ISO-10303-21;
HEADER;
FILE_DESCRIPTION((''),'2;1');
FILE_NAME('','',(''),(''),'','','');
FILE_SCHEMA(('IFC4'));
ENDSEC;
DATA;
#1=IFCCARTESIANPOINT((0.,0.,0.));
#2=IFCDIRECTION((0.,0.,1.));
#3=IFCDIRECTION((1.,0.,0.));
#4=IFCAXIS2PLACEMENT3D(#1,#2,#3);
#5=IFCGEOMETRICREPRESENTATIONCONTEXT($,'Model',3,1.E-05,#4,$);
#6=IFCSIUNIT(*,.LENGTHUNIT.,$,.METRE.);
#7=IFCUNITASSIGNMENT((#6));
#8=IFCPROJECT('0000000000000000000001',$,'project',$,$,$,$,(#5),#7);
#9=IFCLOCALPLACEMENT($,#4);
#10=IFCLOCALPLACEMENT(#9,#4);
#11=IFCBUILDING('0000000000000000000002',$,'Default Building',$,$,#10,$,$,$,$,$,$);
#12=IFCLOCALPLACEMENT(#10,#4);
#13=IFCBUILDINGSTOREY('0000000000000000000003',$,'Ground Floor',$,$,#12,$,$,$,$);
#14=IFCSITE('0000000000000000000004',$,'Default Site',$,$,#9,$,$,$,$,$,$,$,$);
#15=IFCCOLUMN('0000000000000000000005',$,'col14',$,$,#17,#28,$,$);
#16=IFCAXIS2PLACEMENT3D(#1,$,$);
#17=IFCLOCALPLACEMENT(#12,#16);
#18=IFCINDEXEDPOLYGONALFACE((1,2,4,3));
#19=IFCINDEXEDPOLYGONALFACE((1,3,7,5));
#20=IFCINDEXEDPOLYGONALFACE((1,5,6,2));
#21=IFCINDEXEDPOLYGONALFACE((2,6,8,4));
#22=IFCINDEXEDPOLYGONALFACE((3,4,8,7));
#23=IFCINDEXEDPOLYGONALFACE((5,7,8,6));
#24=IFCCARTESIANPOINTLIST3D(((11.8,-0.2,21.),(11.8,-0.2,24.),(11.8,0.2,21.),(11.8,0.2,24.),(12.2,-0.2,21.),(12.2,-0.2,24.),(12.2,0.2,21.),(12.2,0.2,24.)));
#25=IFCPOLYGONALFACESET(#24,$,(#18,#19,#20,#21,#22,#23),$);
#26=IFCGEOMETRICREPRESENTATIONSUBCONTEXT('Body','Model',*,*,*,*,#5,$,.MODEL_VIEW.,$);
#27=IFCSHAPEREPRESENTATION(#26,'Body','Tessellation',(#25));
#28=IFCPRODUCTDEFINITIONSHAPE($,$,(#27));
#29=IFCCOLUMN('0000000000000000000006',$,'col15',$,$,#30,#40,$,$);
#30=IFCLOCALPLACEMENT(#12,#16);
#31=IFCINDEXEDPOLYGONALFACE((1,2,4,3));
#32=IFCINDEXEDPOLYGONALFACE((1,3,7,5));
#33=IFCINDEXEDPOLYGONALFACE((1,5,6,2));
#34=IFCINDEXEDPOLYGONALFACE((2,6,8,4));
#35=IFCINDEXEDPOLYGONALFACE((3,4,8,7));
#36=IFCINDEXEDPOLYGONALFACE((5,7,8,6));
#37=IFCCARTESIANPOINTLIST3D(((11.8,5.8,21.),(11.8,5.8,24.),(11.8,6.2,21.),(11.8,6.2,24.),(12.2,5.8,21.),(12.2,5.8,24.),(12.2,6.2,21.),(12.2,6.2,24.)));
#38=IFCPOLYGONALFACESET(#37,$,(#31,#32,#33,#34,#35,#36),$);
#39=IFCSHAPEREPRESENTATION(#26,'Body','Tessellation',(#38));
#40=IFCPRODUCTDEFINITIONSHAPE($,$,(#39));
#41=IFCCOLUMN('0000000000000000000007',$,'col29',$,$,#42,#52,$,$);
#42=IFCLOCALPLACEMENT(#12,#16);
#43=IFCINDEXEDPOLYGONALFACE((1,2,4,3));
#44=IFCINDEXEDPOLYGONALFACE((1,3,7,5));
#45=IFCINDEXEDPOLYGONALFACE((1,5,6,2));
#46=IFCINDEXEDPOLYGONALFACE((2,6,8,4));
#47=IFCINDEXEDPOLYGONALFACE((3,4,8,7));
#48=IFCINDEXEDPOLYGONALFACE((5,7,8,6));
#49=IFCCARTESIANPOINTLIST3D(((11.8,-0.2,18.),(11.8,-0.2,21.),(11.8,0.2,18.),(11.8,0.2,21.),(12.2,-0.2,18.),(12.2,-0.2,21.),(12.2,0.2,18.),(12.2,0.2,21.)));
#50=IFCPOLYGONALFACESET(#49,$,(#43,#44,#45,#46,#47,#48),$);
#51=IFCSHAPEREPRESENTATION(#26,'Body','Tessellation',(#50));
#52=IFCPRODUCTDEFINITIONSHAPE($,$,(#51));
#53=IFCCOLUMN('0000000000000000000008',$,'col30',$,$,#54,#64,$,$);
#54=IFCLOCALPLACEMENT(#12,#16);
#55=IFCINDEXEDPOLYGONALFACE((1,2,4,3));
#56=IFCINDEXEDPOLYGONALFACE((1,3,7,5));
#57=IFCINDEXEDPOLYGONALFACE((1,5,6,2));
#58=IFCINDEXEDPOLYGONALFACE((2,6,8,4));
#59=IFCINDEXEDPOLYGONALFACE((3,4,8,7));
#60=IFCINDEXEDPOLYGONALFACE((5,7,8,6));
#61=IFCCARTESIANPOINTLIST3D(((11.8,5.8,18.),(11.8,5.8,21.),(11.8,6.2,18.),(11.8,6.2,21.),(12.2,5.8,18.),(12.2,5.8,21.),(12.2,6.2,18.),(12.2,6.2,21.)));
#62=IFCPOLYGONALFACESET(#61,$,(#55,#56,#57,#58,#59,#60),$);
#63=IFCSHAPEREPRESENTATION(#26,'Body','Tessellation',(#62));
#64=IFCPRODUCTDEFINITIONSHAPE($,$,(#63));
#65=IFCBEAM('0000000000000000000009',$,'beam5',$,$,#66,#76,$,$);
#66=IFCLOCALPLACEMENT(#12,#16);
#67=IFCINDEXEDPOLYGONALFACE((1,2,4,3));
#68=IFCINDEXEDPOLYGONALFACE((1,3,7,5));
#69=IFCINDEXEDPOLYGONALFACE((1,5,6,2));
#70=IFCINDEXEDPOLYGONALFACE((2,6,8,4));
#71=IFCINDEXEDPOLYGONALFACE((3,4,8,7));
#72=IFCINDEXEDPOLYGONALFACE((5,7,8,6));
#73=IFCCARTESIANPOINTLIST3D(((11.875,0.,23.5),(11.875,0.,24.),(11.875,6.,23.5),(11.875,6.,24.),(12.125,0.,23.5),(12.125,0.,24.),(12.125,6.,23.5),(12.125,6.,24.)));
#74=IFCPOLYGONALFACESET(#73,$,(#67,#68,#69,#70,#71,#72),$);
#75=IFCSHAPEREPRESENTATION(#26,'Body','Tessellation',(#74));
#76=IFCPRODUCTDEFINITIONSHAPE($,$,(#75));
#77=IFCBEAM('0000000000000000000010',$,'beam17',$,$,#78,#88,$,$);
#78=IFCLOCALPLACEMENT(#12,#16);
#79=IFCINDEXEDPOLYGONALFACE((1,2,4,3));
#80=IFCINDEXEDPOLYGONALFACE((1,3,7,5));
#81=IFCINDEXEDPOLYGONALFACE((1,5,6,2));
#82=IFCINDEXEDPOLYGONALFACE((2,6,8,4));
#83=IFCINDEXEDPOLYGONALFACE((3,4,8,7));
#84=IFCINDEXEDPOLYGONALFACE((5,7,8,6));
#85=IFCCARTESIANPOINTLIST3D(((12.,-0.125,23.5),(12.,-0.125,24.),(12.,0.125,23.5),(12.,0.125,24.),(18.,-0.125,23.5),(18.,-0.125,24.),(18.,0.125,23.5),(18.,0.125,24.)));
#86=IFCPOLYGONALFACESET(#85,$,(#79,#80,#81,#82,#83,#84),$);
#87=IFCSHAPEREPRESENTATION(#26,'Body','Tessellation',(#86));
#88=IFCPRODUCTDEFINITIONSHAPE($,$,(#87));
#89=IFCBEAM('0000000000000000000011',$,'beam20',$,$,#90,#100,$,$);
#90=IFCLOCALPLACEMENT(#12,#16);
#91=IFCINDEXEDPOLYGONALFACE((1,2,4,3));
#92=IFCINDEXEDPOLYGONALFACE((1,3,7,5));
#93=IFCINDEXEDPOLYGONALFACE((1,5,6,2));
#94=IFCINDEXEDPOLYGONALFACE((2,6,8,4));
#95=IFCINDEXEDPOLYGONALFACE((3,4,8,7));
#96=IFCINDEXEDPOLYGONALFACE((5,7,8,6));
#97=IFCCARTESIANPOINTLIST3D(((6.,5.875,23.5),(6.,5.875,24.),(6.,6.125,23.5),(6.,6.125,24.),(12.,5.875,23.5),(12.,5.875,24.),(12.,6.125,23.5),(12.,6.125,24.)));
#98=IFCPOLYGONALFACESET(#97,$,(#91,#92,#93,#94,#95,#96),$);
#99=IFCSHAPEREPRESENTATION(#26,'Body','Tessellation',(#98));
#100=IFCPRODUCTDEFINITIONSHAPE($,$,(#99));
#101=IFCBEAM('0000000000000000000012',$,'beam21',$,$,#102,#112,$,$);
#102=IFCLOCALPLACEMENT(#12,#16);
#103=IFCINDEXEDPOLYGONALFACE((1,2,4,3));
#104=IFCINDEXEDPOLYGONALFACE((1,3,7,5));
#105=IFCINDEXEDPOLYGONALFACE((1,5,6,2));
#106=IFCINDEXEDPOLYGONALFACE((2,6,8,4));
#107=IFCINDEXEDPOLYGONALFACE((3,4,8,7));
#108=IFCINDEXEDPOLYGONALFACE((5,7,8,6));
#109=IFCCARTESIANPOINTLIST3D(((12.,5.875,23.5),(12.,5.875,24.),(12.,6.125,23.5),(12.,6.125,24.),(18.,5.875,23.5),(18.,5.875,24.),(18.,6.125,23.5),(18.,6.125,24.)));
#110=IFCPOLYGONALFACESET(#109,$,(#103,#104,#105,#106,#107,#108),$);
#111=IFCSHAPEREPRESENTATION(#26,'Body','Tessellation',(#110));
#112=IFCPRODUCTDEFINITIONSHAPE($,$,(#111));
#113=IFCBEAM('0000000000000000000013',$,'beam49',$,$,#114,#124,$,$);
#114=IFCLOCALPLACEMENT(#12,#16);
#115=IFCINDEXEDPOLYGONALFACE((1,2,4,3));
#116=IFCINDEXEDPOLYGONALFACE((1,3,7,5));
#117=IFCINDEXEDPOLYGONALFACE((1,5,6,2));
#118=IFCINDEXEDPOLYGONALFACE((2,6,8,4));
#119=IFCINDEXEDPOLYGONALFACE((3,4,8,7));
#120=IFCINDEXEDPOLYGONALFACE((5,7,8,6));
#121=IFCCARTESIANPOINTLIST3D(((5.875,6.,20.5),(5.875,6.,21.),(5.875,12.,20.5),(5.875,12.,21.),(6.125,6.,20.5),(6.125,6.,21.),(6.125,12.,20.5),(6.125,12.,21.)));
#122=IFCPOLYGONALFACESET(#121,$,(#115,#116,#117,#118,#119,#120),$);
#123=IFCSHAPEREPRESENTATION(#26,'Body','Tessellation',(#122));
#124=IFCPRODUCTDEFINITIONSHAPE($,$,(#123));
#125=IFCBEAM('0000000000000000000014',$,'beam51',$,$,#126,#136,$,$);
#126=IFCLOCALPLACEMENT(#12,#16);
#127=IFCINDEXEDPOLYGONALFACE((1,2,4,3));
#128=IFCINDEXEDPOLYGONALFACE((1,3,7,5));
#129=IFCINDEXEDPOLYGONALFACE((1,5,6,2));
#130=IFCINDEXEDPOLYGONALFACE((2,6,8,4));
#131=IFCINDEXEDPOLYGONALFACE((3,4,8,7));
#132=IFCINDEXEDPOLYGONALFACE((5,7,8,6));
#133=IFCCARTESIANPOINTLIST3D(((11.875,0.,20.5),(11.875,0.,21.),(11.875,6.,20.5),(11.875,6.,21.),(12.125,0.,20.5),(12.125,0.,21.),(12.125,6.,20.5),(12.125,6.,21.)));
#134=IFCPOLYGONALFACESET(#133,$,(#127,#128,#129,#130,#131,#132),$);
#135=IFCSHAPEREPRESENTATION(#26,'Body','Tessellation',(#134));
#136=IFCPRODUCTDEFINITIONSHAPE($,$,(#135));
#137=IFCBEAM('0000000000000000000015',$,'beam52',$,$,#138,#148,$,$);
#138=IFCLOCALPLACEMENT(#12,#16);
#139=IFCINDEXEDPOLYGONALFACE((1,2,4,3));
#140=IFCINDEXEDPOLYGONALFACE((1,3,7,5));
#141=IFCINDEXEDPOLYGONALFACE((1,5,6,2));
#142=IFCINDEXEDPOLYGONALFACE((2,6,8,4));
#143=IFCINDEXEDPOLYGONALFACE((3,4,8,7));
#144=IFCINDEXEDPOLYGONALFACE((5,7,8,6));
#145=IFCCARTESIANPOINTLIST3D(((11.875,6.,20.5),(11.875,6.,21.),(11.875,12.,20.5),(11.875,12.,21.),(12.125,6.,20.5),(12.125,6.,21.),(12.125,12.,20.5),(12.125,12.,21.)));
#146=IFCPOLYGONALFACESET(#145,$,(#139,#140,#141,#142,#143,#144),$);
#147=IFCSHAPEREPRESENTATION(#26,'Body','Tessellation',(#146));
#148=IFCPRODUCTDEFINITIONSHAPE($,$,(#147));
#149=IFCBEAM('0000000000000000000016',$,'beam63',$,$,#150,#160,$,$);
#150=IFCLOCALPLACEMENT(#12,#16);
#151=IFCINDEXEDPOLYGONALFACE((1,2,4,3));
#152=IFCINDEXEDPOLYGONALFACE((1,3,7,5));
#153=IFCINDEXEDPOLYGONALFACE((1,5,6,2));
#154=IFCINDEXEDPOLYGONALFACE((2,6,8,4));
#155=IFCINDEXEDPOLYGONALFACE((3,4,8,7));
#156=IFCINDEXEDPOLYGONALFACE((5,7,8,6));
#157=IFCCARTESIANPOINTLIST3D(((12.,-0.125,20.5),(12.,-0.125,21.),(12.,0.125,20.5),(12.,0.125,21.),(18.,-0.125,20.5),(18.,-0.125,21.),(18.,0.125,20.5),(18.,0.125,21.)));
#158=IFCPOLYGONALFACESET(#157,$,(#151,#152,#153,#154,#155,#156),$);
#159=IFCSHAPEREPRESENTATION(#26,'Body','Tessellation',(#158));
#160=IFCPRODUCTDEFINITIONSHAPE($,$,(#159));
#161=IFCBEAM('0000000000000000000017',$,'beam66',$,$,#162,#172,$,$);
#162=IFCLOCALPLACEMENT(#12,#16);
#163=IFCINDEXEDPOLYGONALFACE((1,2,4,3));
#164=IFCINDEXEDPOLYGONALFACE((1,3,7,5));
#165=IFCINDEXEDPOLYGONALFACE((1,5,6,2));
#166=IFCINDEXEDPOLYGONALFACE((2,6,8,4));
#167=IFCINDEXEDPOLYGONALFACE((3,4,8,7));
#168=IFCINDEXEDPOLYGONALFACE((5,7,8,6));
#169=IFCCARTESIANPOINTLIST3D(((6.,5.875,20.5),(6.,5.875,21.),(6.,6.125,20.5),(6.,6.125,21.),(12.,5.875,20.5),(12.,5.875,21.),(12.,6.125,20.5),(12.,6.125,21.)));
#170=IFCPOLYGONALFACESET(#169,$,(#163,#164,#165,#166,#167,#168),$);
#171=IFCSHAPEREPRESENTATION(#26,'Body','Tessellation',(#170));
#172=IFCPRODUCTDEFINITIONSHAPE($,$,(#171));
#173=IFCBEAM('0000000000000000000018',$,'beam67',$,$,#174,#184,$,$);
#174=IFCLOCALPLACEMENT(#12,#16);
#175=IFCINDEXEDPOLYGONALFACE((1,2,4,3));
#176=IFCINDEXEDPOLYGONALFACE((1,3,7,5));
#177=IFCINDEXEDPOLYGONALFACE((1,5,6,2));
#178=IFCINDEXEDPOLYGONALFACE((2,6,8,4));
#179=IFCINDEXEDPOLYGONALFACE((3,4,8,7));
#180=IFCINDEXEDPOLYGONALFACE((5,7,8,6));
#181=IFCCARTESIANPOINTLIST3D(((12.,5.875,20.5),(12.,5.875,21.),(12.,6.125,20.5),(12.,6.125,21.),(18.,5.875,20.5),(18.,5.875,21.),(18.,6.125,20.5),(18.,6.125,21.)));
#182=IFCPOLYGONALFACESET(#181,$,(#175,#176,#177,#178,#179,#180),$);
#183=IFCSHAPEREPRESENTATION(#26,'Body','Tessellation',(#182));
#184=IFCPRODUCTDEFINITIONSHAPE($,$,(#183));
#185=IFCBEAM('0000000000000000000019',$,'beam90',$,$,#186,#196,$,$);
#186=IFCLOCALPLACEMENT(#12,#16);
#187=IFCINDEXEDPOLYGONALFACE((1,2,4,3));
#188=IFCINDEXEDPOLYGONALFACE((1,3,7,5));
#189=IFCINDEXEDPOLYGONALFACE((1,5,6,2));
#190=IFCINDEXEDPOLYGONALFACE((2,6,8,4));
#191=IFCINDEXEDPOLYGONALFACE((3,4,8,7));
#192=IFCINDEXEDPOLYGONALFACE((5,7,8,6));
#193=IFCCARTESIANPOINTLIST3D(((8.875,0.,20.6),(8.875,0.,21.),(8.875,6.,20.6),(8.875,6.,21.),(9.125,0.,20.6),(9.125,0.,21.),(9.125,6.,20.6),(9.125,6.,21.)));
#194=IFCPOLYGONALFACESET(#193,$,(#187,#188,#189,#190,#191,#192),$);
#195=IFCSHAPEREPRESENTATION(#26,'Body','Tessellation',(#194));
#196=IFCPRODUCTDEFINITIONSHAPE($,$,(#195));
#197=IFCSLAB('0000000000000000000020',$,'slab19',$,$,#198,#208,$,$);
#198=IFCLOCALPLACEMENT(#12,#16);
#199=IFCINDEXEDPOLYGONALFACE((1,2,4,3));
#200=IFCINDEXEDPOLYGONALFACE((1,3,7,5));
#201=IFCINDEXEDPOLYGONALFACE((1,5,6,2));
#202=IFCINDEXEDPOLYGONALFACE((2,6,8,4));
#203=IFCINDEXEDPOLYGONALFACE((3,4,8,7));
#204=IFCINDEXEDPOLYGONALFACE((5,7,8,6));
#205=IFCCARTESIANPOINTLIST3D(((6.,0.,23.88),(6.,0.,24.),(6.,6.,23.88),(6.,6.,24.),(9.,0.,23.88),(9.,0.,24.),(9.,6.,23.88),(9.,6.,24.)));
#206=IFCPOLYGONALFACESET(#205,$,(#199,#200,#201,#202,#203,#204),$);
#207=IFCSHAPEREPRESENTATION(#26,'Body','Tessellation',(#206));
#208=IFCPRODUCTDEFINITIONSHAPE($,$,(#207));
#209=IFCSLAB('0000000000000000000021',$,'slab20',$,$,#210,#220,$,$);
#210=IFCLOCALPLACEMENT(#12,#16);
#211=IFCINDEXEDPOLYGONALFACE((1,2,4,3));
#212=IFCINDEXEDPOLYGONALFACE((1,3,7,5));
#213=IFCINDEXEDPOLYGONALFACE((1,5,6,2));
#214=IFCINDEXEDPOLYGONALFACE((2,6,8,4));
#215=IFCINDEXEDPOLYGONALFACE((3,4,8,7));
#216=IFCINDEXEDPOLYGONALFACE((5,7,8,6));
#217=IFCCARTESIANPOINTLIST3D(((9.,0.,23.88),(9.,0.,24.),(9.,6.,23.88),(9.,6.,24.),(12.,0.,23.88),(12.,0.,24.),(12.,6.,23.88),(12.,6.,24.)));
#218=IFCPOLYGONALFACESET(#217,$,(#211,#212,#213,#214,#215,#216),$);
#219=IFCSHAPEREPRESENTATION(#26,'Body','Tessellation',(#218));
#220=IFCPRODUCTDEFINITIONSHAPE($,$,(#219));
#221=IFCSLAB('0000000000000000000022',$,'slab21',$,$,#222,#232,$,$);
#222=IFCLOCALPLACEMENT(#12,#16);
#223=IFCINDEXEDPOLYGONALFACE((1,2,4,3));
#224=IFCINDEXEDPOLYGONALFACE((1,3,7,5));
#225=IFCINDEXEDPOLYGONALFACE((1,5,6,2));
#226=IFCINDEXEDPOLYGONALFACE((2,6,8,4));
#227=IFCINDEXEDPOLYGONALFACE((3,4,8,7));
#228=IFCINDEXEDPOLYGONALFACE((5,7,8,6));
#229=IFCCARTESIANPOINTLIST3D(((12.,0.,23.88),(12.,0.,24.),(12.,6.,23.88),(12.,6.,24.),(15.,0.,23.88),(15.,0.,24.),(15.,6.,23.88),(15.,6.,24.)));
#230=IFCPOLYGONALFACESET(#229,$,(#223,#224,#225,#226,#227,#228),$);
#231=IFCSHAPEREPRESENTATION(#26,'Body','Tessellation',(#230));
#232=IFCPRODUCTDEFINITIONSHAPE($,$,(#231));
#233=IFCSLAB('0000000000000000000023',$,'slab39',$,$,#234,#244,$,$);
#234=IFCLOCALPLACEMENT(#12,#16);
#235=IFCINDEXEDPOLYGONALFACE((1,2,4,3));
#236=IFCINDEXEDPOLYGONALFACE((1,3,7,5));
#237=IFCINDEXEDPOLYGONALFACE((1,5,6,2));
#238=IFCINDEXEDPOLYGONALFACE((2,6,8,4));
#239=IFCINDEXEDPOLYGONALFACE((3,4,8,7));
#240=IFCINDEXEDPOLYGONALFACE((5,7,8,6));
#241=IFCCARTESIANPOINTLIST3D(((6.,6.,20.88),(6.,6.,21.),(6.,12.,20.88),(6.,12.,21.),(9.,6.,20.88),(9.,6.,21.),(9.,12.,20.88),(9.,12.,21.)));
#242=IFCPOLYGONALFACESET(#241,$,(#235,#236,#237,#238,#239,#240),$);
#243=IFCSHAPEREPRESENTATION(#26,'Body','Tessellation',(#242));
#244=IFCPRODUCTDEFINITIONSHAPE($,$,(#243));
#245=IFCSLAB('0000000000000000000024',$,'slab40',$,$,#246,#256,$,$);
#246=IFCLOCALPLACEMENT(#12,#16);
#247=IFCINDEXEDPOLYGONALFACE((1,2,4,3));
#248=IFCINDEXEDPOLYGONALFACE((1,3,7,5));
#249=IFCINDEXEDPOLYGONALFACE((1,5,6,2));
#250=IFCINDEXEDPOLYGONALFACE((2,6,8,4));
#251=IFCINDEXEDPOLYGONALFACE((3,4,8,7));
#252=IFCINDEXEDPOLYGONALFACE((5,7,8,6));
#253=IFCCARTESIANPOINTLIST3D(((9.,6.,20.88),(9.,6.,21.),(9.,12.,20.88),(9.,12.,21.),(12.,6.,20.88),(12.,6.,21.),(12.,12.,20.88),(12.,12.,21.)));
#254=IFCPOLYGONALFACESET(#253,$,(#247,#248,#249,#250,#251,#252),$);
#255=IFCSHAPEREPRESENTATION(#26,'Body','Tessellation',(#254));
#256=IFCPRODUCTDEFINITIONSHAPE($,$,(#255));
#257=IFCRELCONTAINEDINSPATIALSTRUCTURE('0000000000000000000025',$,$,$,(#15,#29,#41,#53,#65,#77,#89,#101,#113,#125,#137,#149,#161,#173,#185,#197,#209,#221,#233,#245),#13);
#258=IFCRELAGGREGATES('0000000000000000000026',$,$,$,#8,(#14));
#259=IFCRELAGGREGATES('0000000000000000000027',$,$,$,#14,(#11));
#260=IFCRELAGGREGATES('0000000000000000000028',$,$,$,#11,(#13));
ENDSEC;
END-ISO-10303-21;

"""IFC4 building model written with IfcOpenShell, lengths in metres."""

from ifc_helpers import new_model, si_unit, frame, origin_with_axes, place, context, subcontext, project, spatial, indexed_curve, outline, extrude, element, save


model = new_model("IFC4")

# Units and contexts
model_context = context("Model", 3, precision=1e-05, world=origin_with_axes())
body_context = subcontext(model_context, "Body", "Model", "MODEL_VIEW")
ifc_project = project(units=[si_unit("LENGTHUNIT", "METRE")], contexts=[model_context])

# Site, building, storey
site_placement = place(None, origin_with_axes())
site = spatial("IfcSite", under=ifc_project, at=site_placement, Name="Default Site")
building_placement = place(site_placement, origin_with_axes())
building = spatial("IfcBuilding", under=site, at=building_placement, Name="Default Building")
storey_placement = place(building_placement, origin_with_axes())
storey = spatial("IfcBuildingStorey", under=building, at=storey_placement, Name="Ground Floor")

# Columns
for number, where, z_axis, x_axis, name in (
    (1, (11.8, -0.2, 21.0), (0.0, 0.0, 1.0), (1.0, 0.0, 0.0), "col14"),
    (2, (11.8, 5.8, 21.0), (0.0, 0.0, 1.0), (1.0, 0.0, 0.0), "col15"),
    (3, (11.8, -0.2, 18.0), (0.0, 0.0, 1.0), (1.0, 0.0, 0.0), "col29"),
    (4, (11.8, 5.8, 18.0), (0.0, 0.0, 1.0), (1.0, 0.0, 0.0), "col30"),
):
    element("IfcColumn", number, at=place(storey_placement, frame(where, z_axis=z_axis, x_axis=x_axis)), inside=storey, Name=name, context=body_context, shape_type="SweptSolid", body=[
        extrude(outline(indexed_curve([(0.0, 0.0), (0.0, 0.4), (0.4, 0.4), (0.4, 0.0), (0.0, 0.0)], self_intersect=False)), origin_with_axes(), (0.0, 0.0, 1.0), 3.0),
    ])

# Beams
for number, where, z_axis, x_axis, name in (
    (5, (12.125, 0.0, 23.5), (0.0, 0.0, 1.0), (0.0, 1.0, 0.0), "beam5"),
    (6, (12.0, -0.125, 23.5), (0.0, 0.0, 1.0), (1.0, 0.0, 0.0), "beam17"),
    (7, (6.0, 5.875, 23.5), (0.0, 0.0, 1.0), (1.0, 0.0, 0.0), "beam20"),
    (8, (12.0, 5.875, 23.5), (0.0, 0.0, 1.0), (1.0, 0.0, 0.0), "beam21"),
    (9, (6.125, 6.0, 20.5), (0.0, 0.0, 1.0), (0.0, 1.0, 0.0), "beam49"),
    (10, (12.125, 0.0, 20.5), (0.0, 0.0, 1.0), (0.0, 1.0, 0.0), "beam51"),
    (11, (12.125, 6.0, 20.5), (0.0, 0.0, 1.0), (0.0, 1.0, 0.0), "beam52"),
    (12, (12.0, -0.125, 20.5), (0.0, 0.0, 1.0), (1.0, 0.0, 0.0), "beam63"),
    (13, (6.0, 5.875, 20.5), (0.0, 0.0, 1.0), (1.0, 0.0, 0.0), "beam66"),
    (14, (12.0, 5.875, 20.5), (0.0, 0.0, 1.0), (1.0, 0.0, 0.0), "beam67"),
):
    element("IfcBeam", number, at=place(storey_placement, frame(where, z_axis=z_axis, x_axis=x_axis)), inside=storey, Name=name, context=body_context, shape_type="SweptSolid", body=[
        extrude(outline(indexed_curve([(0.0, 0.0), (0.0, 0.25), (6.0, 0.25), (6.0, 0.0), (0.0, 0.0)], self_intersect=False)), origin_with_axes(), (0.0, 0.0, 1.0), 0.5),
    ])
beam_placement = place(storey_placement, frame((8.875, 6.0, 20.6), z_axis=(0.0, 0.0, 1.0), x_axis=(0.0, -1.0, 0.0)))
element("IfcBeam", 15, at=beam_placement, inside=storey, Name="beam90", context=body_context, shape_type="SweptSolid", body=[
    extrude(outline(indexed_curve([(0.0, 0.0), (0.0, 0.25), (6.0, 0.25), (6.0, 0.0), (0.0, 0.0)], self_intersect=False)), origin_with_axes(), (0.0, 0.0, 1.0), 0.4),
])

# Slabs
for number, where, z_axis, x_axis, name in (
    (16, (6.0, 0.0, 23.88), (0.0, 0.0, 1.0), (1.0, 0.0, 0.0), "slab19"),
    (17, (9.0, 0.0, 23.88), (0.0, 0.0, 1.0), (1.0, 0.0, 0.0), "slab20"),
    (18, (12.0, 0.0, 23.88), (0.0, 0.0, 1.0), (1.0, 0.0, 0.0), "slab21"),
    (19, (6.0, 6.0, 20.88), (0.0, 0.0, 1.0), (1.0, 0.0, 0.0), "slab39"),
    (20, (9.0, 6.0, 20.88), (0.0, 0.0, 1.0), (1.0, 0.0, 0.0), "slab40"),
):
    element("IfcSlab", number, at=place(storey_placement, frame(where, z_axis=z_axis, x_axis=x_axis)), inside=storey, Name=name, context=body_context, shape_type="SweptSolid", body=[
        extrude(outline(indexed_curve([(0.0, 0.0), (0.0, 6.0), (3.0, 6.0), (3.0, 0.0), (0.0, 0.0)], self_intersect=False)), origin_with_axes(), (0.0, 0.0, 1.0), 0.12),
    ])

save(model, "model.ifc")
